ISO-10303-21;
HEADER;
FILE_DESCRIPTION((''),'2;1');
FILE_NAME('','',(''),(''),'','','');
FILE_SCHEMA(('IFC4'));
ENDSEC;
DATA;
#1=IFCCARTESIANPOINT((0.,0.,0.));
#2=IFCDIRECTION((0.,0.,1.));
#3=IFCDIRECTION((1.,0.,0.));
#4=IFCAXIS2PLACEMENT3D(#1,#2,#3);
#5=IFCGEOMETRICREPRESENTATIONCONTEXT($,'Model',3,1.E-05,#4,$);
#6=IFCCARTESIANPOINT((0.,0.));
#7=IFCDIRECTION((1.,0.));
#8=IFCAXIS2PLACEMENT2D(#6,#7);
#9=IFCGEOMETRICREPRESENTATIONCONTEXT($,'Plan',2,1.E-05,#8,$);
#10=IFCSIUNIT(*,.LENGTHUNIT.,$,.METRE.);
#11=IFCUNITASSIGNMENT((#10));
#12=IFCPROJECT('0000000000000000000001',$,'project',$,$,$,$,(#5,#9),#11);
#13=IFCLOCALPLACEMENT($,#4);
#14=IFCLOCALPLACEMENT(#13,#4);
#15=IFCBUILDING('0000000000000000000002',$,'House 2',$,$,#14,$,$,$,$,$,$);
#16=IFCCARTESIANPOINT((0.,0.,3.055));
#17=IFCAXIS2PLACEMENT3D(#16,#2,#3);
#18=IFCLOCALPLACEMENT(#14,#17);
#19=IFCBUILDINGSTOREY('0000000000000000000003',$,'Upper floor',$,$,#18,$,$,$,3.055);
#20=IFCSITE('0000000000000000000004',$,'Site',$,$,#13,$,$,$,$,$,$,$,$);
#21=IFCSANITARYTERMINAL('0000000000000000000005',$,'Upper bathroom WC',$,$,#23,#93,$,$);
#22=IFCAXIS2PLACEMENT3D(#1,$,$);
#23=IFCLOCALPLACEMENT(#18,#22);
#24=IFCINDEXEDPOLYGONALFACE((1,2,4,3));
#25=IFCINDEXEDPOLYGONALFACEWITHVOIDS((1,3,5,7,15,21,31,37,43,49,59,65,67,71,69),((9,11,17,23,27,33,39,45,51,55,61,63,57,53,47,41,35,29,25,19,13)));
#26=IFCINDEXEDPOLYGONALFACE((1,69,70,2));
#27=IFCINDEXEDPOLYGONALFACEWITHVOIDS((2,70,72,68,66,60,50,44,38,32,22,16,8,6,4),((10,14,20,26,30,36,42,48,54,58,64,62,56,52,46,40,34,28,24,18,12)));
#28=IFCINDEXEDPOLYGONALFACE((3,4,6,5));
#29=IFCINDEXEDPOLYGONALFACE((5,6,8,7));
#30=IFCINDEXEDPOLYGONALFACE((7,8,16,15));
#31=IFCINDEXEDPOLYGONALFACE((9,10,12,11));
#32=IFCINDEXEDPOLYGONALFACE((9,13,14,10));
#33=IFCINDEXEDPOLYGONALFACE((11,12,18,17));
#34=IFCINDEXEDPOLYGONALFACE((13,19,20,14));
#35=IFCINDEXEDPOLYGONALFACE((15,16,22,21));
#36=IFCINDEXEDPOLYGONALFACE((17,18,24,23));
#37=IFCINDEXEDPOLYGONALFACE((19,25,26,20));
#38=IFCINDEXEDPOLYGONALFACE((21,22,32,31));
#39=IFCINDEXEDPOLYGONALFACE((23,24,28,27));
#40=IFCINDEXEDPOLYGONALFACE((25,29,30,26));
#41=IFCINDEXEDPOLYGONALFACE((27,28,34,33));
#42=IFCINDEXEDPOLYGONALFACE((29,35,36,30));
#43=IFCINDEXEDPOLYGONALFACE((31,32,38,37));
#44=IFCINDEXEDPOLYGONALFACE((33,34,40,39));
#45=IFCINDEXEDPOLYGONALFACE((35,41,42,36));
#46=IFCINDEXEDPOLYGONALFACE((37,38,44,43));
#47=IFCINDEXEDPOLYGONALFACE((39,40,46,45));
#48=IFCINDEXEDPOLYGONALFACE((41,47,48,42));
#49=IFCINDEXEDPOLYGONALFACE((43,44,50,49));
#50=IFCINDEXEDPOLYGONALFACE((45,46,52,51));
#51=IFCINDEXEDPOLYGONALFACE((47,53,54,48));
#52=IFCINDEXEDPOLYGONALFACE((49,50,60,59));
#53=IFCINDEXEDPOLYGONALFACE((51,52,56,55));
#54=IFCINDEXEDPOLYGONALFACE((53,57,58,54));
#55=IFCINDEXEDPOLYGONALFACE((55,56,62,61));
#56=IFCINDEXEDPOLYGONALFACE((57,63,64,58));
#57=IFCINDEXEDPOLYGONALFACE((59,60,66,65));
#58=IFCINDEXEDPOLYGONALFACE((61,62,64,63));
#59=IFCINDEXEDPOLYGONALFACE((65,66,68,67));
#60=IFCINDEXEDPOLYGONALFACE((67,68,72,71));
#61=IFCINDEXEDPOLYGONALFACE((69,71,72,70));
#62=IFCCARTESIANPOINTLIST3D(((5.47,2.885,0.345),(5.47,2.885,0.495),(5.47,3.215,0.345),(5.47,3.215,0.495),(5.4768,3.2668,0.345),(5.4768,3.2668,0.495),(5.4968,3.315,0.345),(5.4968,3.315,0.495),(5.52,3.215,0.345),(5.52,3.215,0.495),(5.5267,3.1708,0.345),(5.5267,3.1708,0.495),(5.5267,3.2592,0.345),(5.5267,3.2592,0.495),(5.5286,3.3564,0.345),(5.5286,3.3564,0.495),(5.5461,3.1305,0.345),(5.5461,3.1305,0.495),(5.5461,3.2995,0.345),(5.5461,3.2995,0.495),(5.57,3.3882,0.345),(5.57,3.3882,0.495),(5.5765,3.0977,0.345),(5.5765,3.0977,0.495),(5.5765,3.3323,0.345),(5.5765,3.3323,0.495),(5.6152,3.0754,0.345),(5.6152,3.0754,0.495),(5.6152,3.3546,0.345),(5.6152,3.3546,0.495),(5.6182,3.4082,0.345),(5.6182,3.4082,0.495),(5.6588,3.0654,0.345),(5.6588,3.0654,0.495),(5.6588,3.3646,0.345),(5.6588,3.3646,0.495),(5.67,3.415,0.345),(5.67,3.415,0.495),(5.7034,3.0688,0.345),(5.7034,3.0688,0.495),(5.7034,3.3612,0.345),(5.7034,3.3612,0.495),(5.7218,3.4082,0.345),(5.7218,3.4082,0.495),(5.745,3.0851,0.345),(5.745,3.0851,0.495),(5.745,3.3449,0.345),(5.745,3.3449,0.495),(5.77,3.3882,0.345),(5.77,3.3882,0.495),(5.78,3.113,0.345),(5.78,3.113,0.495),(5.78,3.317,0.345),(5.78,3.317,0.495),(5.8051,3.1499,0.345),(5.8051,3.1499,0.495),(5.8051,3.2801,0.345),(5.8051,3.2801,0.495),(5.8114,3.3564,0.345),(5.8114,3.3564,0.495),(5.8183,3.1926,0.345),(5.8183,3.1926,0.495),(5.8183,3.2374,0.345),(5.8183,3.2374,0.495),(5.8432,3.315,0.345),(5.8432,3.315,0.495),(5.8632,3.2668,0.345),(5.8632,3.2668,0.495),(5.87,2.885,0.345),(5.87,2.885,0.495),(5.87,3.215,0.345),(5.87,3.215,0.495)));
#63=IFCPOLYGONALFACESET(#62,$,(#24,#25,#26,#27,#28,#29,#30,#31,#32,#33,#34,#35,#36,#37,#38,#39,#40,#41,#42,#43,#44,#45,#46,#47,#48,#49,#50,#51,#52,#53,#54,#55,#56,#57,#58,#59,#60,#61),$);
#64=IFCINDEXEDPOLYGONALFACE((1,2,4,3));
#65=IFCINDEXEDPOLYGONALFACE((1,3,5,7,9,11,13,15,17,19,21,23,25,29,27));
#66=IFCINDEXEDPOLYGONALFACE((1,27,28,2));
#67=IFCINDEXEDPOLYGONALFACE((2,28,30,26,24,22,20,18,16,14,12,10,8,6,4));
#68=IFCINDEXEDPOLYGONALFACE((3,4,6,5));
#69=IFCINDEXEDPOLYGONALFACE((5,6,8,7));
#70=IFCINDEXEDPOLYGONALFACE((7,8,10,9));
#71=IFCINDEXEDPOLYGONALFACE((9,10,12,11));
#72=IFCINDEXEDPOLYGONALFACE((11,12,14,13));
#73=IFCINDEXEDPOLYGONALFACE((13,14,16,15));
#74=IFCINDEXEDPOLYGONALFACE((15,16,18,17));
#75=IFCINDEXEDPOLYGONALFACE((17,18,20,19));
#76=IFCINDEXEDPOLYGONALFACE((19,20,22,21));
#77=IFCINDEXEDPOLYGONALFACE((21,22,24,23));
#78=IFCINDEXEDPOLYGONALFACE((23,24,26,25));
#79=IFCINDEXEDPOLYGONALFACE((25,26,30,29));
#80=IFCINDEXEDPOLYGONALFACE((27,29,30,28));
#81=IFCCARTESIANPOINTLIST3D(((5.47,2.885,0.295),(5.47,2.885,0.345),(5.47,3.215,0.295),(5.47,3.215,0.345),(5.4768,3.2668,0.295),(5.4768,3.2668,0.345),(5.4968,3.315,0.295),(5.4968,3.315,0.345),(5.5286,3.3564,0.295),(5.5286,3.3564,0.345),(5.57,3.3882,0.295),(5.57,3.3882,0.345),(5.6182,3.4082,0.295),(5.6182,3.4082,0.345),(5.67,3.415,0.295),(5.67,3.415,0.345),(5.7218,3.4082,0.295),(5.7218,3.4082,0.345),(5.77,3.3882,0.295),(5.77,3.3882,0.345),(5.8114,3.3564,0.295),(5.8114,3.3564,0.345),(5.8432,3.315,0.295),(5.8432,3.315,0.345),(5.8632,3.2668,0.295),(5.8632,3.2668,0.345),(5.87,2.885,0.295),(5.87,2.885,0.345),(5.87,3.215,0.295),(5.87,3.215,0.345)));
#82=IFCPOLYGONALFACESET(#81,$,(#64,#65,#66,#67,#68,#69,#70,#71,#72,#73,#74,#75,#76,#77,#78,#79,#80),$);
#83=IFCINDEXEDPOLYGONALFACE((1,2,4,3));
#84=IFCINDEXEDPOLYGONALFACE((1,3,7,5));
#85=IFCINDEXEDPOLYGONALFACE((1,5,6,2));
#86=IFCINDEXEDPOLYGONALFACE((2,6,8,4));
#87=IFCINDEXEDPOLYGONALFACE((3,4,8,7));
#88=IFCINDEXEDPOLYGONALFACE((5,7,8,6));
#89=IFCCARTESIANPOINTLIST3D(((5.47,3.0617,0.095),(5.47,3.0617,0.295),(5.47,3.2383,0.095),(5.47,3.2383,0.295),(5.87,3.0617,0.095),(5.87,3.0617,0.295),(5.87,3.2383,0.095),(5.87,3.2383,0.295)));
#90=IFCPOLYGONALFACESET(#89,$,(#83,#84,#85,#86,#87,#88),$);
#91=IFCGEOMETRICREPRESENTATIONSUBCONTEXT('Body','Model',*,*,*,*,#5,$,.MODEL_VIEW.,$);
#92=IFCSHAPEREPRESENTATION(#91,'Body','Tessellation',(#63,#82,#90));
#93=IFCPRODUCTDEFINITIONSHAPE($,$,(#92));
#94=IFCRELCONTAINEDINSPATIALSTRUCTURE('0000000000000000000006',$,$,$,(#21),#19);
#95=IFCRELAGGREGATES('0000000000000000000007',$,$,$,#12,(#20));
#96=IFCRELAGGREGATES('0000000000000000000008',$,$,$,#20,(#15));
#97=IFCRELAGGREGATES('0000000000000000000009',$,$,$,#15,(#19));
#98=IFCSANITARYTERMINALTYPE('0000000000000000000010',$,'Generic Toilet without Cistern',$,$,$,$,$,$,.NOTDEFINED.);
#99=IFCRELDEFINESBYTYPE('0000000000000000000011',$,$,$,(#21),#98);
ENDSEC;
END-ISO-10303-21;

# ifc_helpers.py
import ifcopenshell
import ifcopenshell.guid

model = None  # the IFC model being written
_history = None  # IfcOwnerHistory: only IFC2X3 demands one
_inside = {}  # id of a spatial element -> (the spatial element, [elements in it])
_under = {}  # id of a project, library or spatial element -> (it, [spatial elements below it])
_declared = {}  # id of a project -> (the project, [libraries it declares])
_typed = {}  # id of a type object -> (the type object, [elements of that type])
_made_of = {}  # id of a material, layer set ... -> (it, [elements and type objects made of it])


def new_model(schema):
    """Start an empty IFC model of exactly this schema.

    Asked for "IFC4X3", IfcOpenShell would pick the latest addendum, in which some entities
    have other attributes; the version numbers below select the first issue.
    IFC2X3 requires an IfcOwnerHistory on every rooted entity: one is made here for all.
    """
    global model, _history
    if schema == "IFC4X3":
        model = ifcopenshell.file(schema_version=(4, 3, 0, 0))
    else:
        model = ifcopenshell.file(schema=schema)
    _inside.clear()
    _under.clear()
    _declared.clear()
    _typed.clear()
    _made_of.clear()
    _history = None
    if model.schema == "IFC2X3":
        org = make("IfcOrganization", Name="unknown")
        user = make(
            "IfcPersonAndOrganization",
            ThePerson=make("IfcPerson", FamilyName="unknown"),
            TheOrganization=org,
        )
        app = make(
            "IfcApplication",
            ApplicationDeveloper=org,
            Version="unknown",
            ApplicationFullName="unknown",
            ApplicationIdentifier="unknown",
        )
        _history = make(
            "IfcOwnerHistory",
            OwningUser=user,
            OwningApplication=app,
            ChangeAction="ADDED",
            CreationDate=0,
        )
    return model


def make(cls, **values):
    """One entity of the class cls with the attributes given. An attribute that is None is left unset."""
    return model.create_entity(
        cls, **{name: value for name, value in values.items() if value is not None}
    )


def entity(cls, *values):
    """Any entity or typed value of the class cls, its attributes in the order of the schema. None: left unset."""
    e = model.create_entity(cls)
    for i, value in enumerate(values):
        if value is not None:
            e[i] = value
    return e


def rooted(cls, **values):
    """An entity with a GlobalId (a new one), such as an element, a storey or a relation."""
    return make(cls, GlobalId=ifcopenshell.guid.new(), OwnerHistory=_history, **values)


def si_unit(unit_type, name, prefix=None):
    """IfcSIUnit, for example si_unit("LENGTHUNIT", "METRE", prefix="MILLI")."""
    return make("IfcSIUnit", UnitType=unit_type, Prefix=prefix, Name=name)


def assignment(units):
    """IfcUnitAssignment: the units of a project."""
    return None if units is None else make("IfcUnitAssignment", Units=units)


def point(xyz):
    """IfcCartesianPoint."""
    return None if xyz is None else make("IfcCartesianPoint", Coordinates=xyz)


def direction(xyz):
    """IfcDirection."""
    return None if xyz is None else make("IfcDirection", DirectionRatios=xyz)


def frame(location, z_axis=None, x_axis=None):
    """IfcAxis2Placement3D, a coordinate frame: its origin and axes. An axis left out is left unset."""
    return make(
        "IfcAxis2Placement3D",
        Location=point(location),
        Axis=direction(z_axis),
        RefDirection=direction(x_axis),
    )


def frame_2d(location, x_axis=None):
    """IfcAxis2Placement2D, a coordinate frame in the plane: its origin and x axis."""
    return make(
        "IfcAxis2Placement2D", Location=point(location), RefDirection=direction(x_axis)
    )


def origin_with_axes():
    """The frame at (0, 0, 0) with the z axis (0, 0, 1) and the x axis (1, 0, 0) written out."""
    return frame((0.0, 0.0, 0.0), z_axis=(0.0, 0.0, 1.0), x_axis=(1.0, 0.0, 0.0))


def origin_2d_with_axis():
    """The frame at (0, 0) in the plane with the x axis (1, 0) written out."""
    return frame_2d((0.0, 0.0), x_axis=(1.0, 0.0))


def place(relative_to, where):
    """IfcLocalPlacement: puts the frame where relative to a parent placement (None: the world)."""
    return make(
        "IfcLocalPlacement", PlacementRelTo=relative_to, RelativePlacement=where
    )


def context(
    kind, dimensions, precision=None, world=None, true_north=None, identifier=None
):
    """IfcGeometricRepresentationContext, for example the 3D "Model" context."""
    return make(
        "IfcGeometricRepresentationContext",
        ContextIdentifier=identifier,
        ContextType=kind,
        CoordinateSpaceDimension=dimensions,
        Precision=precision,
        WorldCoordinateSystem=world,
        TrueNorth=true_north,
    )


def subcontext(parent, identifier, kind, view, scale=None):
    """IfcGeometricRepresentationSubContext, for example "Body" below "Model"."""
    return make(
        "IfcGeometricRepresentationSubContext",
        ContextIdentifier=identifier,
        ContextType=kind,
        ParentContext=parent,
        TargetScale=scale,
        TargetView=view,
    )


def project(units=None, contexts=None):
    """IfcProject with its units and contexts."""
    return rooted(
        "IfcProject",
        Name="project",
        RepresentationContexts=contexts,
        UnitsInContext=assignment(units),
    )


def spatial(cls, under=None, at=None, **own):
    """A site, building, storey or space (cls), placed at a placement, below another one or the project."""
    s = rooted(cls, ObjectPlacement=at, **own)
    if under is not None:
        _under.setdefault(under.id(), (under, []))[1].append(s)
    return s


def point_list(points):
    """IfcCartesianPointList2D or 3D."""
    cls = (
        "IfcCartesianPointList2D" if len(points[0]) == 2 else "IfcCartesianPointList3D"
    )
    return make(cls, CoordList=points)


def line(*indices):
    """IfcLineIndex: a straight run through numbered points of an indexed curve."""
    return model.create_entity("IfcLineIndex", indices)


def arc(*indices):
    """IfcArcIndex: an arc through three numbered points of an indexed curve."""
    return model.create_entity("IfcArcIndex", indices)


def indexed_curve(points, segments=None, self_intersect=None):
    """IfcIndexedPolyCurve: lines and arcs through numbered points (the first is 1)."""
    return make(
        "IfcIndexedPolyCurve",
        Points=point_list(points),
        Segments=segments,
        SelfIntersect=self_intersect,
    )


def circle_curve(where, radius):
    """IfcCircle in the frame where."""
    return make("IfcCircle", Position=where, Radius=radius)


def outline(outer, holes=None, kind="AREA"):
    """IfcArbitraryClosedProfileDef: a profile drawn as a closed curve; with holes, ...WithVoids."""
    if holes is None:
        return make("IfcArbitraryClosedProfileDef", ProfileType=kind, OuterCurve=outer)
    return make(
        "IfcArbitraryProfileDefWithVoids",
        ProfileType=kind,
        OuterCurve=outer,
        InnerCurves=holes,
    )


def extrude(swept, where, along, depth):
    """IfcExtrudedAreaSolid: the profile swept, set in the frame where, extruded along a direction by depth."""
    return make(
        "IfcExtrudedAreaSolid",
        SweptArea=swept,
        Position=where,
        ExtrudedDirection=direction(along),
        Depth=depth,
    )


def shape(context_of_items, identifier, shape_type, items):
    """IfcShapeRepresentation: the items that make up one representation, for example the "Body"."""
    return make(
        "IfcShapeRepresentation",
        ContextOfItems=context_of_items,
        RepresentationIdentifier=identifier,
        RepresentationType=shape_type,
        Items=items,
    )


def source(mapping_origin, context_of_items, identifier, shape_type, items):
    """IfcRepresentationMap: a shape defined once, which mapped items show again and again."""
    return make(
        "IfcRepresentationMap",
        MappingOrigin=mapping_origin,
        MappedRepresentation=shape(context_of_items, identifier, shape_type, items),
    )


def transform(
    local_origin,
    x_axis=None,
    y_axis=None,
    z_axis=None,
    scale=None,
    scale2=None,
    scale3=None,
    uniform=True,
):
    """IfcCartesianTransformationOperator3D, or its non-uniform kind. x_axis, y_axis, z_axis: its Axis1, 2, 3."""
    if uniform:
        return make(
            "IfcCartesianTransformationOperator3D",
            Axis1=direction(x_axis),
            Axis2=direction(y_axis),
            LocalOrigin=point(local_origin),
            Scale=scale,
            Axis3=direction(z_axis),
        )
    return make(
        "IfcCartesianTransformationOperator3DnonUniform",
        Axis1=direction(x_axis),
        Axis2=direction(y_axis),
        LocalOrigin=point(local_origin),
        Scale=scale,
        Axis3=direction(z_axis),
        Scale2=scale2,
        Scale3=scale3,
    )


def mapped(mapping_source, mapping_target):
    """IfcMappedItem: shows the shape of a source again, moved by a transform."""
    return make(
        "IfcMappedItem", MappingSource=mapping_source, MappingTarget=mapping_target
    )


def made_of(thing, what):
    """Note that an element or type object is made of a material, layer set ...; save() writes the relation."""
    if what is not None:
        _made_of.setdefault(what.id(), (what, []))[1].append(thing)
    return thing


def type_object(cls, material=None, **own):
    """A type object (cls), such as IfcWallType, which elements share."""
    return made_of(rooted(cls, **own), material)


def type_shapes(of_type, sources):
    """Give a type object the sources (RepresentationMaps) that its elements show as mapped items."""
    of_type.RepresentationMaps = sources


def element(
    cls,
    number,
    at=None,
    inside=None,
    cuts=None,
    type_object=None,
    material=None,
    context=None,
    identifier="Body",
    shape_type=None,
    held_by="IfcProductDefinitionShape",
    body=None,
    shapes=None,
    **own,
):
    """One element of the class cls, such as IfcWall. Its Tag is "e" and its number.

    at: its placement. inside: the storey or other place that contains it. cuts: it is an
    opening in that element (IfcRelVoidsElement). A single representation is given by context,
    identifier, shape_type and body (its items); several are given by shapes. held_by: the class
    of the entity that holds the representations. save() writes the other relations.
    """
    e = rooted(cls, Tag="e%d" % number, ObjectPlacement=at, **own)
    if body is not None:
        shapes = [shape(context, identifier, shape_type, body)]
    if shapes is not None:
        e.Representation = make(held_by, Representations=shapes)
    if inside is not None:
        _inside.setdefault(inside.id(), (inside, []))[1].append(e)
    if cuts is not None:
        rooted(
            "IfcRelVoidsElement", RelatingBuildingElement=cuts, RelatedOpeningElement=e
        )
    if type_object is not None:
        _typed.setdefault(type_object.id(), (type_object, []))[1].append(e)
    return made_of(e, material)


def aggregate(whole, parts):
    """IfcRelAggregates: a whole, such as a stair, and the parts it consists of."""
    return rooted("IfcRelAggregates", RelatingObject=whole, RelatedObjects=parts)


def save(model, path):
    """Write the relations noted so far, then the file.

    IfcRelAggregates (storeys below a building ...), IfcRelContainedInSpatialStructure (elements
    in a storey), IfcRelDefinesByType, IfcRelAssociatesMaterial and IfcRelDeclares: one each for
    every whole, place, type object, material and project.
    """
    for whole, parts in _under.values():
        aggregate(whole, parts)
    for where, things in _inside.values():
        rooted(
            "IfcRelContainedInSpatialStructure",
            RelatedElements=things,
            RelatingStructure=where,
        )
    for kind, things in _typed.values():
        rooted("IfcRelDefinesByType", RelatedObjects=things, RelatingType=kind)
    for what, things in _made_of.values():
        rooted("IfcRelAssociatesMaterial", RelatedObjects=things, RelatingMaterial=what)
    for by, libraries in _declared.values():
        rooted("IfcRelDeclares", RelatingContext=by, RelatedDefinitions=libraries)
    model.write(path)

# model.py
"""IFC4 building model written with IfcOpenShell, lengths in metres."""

from ifc_helpers import new_model, entity, si_unit, frame, frame_2d, origin_with_axes, origin_2d_with_axis, place, context, subcontext, project, spatial, line, arc, indexed_curve, circle_curve, outline, extrude, shape, source, transform, mapped, type_object, type_shapes, element, save


model = new_model("IFC4")

# Units and contexts
model_context = context("Model", 3, precision=1e-05, world=origin_with_axes())
plan_context = context("Plan", 2, precision=1e-05, world=origin_2d_with_axis())
body_context_1 = subcontext(model_context, "Body", "Model", "MODEL_VIEW")
body_context_2 = subcontext(plan_context, "Body", "Plan", "PLAN_VIEW")
ifc_project = project(units=[si_unit("LENGTHUNIT", "METRE")], contexts=[model_context, plan_context])

# Site, building, storey
site_placement = place(None, origin_with_axes())
site = spatial("IfcSite", under=ifc_project, at=site_placement, Name="Site")
building_placement = place(site_placement, origin_with_axes())
building = spatial("IfcBuilding", under=site, at=building_placement, Name="House 2")
storey_placement = place(building_placement, frame((0.0, 0.0, 3.055), z_axis=(0.0, 0.0, 1.0), x_axis=(1.0, 0.0, 0.0)))
storey = spatial("IfcBuildingStorey", under=building, at=storey_placement, Name="Upper floor", Elevation=3.055)

# Sanitary terminal
sanitary_terminal_type_1 = type_object("IfcSanitaryTerminalType", Name="Generic Toilet without Cistern", PredefinedType="NOTDEFINED")
shared_shape_1 = source(origin_with_axes(), body_context_1, "Body", "SweptSolid", [
    extrude(outline(indexed_curve([(-0.2, 0.0), (0.2, 0.0), (0.2, -0.33), (0.1414, -0.4714), (0.0, -0.53), (-0.1414, -0.4714), (-0.2, -0.33)], segments=[line(1, 2), line(2, 3), arc(3, 4, 5), arc(5, 6, 7), line(7, 1)]), holes=[circle_curve(frame_2d((0.0, -0.33)), 0.15)]), frame((0.0, 0.0, 0.25), z_axis=(0.0, 0.0, 1.0), x_axis=(1.0, 0.0, 0.0)), (0.0, 0.0, 1.0), 0.15),
    extrude(outline(indexed_curve([(-0.2, 0.0), (0.2, 0.0), (0.2, -0.33), (0.1414, -0.4714), (0.0, -0.53), (-0.1414, -0.4714), (-0.2, -0.33)], segments=[line(1, 2), line(2, 3), arc(3, 4, 5), arc(5, 6, 7), line(7, 1)])), frame((0.0, 0.0, 0.2), z_axis=(0.0, 0.0, 1.0), x_axis=(1.0, 0.0, 0.0)), (0.0, 0.0, 1.0), 0.05),
    extrude(outline(indexed_curve([(-0.2, -0.1767), (0.2, -0.1767), (0.2, -0.3533), (-0.2, -0.3533)], segments=[line(1, 2, 3, 4, 1)])), origin_with_axes(), (0.0, 0.0, 1.0), 0.2),
])
shared_shape_2 = source(origin_with_axes(), body_context_2, "Body", "Curve2D", [
    entity("IfcIndexedPolyCurve", entity("IfcCartesianPointList2D", [[-0.12, 0.0], [0.12, 0.0]])),
    entity("IfcIndexedPolyCurve", entity("IfcCartesianPointList2D", [[0.12, 0.0], [0.2, -0.159]])),
    entity("IfcTrimmedCurve", entity("IfcEllipse", entity("IfcAxis2Placement2D", entity("IfcCartesianPoint", [0.0, -0.159]), entity("IfcDirection", [1.0, 0.0])), 0.2, 0.371), [entity("IfcCartesianPoint", [-0.2, -0.159])], [entity("IfcCartesianPoint", [0.2, -0.159])], True, "CARTESIAN"),
    entity("IfcIndexedPolyCurve", entity("IfcCartesianPointList2D", [[-0.12, 0.0], [-0.2, -0.159]])),
    entity("IfcEllipse", entity("IfcAxis2Placement2D", entity("IfcCartesianPoint", [0.0, -0.2968]), entity("IfcDirection", [1.0, 0.0])), 0.15, 0.1855),
    entity("IfcIndexedPolyCurve", entity("IfcCartesianPointList2D", [[-0.025, -0.2968], [-0.025, -0.2703], [0.025, -0.2703], [0.025, -0.2968]])),
    entity("IfcTrimmedCurve", entity("IfcEllipse", entity("IfcAxis2Placement2D", entity("IfcCartesianPoint", [0.0, -0.2968]), entity("IfcDirection", [1.0, 0.0])), 0.025, 0.0265), [entity("IfcCartesianPoint", [-0.025, -0.2968])], [entity("IfcCartesianPoint", [0.025, -0.2968])], True, "CARTESIAN"),
])
type_shapes(sanitary_terminal_type_1, [shared_shape_1, shared_shape_2])
sanitary_terminal_1_placement = place(storey_placement, frame((5.67, 2.885, 0.095), z_axis=(0.0, 0.0, 1.0), x_axis=(-1.0, 0.0, 0.0)))
element("IfcSanitaryTerminal", 1, at=sanitary_terminal_1_placement, inside=storey, type_object=sanitary_terminal_type_1, Name="Upper bathroom WC", shapes=[
    shape(body_context_1, "Body", "MappedRepresentation", [mapped(shared_shape_1, transform((0.0, 0.0, 0.0), x_axis=(1.0, 0.0, 0.0), y_axis=(0.0, 1.0, 0.0), z_axis=(0.0, 0.0, 1.0), scale=1.0))]),
    shape(body_context_2, "Body", "MappedRepresentation", [mapped(shared_shape_2, transform((0.0, 0.0, 0.0), x_axis=(1.0, 0.0, 0.0), y_axis=(0.0, 1.0, 0.0), z_axis=(0.0, 0.0, 1.0), scale=1.0))]),
])

save(model, "model.ifc")
